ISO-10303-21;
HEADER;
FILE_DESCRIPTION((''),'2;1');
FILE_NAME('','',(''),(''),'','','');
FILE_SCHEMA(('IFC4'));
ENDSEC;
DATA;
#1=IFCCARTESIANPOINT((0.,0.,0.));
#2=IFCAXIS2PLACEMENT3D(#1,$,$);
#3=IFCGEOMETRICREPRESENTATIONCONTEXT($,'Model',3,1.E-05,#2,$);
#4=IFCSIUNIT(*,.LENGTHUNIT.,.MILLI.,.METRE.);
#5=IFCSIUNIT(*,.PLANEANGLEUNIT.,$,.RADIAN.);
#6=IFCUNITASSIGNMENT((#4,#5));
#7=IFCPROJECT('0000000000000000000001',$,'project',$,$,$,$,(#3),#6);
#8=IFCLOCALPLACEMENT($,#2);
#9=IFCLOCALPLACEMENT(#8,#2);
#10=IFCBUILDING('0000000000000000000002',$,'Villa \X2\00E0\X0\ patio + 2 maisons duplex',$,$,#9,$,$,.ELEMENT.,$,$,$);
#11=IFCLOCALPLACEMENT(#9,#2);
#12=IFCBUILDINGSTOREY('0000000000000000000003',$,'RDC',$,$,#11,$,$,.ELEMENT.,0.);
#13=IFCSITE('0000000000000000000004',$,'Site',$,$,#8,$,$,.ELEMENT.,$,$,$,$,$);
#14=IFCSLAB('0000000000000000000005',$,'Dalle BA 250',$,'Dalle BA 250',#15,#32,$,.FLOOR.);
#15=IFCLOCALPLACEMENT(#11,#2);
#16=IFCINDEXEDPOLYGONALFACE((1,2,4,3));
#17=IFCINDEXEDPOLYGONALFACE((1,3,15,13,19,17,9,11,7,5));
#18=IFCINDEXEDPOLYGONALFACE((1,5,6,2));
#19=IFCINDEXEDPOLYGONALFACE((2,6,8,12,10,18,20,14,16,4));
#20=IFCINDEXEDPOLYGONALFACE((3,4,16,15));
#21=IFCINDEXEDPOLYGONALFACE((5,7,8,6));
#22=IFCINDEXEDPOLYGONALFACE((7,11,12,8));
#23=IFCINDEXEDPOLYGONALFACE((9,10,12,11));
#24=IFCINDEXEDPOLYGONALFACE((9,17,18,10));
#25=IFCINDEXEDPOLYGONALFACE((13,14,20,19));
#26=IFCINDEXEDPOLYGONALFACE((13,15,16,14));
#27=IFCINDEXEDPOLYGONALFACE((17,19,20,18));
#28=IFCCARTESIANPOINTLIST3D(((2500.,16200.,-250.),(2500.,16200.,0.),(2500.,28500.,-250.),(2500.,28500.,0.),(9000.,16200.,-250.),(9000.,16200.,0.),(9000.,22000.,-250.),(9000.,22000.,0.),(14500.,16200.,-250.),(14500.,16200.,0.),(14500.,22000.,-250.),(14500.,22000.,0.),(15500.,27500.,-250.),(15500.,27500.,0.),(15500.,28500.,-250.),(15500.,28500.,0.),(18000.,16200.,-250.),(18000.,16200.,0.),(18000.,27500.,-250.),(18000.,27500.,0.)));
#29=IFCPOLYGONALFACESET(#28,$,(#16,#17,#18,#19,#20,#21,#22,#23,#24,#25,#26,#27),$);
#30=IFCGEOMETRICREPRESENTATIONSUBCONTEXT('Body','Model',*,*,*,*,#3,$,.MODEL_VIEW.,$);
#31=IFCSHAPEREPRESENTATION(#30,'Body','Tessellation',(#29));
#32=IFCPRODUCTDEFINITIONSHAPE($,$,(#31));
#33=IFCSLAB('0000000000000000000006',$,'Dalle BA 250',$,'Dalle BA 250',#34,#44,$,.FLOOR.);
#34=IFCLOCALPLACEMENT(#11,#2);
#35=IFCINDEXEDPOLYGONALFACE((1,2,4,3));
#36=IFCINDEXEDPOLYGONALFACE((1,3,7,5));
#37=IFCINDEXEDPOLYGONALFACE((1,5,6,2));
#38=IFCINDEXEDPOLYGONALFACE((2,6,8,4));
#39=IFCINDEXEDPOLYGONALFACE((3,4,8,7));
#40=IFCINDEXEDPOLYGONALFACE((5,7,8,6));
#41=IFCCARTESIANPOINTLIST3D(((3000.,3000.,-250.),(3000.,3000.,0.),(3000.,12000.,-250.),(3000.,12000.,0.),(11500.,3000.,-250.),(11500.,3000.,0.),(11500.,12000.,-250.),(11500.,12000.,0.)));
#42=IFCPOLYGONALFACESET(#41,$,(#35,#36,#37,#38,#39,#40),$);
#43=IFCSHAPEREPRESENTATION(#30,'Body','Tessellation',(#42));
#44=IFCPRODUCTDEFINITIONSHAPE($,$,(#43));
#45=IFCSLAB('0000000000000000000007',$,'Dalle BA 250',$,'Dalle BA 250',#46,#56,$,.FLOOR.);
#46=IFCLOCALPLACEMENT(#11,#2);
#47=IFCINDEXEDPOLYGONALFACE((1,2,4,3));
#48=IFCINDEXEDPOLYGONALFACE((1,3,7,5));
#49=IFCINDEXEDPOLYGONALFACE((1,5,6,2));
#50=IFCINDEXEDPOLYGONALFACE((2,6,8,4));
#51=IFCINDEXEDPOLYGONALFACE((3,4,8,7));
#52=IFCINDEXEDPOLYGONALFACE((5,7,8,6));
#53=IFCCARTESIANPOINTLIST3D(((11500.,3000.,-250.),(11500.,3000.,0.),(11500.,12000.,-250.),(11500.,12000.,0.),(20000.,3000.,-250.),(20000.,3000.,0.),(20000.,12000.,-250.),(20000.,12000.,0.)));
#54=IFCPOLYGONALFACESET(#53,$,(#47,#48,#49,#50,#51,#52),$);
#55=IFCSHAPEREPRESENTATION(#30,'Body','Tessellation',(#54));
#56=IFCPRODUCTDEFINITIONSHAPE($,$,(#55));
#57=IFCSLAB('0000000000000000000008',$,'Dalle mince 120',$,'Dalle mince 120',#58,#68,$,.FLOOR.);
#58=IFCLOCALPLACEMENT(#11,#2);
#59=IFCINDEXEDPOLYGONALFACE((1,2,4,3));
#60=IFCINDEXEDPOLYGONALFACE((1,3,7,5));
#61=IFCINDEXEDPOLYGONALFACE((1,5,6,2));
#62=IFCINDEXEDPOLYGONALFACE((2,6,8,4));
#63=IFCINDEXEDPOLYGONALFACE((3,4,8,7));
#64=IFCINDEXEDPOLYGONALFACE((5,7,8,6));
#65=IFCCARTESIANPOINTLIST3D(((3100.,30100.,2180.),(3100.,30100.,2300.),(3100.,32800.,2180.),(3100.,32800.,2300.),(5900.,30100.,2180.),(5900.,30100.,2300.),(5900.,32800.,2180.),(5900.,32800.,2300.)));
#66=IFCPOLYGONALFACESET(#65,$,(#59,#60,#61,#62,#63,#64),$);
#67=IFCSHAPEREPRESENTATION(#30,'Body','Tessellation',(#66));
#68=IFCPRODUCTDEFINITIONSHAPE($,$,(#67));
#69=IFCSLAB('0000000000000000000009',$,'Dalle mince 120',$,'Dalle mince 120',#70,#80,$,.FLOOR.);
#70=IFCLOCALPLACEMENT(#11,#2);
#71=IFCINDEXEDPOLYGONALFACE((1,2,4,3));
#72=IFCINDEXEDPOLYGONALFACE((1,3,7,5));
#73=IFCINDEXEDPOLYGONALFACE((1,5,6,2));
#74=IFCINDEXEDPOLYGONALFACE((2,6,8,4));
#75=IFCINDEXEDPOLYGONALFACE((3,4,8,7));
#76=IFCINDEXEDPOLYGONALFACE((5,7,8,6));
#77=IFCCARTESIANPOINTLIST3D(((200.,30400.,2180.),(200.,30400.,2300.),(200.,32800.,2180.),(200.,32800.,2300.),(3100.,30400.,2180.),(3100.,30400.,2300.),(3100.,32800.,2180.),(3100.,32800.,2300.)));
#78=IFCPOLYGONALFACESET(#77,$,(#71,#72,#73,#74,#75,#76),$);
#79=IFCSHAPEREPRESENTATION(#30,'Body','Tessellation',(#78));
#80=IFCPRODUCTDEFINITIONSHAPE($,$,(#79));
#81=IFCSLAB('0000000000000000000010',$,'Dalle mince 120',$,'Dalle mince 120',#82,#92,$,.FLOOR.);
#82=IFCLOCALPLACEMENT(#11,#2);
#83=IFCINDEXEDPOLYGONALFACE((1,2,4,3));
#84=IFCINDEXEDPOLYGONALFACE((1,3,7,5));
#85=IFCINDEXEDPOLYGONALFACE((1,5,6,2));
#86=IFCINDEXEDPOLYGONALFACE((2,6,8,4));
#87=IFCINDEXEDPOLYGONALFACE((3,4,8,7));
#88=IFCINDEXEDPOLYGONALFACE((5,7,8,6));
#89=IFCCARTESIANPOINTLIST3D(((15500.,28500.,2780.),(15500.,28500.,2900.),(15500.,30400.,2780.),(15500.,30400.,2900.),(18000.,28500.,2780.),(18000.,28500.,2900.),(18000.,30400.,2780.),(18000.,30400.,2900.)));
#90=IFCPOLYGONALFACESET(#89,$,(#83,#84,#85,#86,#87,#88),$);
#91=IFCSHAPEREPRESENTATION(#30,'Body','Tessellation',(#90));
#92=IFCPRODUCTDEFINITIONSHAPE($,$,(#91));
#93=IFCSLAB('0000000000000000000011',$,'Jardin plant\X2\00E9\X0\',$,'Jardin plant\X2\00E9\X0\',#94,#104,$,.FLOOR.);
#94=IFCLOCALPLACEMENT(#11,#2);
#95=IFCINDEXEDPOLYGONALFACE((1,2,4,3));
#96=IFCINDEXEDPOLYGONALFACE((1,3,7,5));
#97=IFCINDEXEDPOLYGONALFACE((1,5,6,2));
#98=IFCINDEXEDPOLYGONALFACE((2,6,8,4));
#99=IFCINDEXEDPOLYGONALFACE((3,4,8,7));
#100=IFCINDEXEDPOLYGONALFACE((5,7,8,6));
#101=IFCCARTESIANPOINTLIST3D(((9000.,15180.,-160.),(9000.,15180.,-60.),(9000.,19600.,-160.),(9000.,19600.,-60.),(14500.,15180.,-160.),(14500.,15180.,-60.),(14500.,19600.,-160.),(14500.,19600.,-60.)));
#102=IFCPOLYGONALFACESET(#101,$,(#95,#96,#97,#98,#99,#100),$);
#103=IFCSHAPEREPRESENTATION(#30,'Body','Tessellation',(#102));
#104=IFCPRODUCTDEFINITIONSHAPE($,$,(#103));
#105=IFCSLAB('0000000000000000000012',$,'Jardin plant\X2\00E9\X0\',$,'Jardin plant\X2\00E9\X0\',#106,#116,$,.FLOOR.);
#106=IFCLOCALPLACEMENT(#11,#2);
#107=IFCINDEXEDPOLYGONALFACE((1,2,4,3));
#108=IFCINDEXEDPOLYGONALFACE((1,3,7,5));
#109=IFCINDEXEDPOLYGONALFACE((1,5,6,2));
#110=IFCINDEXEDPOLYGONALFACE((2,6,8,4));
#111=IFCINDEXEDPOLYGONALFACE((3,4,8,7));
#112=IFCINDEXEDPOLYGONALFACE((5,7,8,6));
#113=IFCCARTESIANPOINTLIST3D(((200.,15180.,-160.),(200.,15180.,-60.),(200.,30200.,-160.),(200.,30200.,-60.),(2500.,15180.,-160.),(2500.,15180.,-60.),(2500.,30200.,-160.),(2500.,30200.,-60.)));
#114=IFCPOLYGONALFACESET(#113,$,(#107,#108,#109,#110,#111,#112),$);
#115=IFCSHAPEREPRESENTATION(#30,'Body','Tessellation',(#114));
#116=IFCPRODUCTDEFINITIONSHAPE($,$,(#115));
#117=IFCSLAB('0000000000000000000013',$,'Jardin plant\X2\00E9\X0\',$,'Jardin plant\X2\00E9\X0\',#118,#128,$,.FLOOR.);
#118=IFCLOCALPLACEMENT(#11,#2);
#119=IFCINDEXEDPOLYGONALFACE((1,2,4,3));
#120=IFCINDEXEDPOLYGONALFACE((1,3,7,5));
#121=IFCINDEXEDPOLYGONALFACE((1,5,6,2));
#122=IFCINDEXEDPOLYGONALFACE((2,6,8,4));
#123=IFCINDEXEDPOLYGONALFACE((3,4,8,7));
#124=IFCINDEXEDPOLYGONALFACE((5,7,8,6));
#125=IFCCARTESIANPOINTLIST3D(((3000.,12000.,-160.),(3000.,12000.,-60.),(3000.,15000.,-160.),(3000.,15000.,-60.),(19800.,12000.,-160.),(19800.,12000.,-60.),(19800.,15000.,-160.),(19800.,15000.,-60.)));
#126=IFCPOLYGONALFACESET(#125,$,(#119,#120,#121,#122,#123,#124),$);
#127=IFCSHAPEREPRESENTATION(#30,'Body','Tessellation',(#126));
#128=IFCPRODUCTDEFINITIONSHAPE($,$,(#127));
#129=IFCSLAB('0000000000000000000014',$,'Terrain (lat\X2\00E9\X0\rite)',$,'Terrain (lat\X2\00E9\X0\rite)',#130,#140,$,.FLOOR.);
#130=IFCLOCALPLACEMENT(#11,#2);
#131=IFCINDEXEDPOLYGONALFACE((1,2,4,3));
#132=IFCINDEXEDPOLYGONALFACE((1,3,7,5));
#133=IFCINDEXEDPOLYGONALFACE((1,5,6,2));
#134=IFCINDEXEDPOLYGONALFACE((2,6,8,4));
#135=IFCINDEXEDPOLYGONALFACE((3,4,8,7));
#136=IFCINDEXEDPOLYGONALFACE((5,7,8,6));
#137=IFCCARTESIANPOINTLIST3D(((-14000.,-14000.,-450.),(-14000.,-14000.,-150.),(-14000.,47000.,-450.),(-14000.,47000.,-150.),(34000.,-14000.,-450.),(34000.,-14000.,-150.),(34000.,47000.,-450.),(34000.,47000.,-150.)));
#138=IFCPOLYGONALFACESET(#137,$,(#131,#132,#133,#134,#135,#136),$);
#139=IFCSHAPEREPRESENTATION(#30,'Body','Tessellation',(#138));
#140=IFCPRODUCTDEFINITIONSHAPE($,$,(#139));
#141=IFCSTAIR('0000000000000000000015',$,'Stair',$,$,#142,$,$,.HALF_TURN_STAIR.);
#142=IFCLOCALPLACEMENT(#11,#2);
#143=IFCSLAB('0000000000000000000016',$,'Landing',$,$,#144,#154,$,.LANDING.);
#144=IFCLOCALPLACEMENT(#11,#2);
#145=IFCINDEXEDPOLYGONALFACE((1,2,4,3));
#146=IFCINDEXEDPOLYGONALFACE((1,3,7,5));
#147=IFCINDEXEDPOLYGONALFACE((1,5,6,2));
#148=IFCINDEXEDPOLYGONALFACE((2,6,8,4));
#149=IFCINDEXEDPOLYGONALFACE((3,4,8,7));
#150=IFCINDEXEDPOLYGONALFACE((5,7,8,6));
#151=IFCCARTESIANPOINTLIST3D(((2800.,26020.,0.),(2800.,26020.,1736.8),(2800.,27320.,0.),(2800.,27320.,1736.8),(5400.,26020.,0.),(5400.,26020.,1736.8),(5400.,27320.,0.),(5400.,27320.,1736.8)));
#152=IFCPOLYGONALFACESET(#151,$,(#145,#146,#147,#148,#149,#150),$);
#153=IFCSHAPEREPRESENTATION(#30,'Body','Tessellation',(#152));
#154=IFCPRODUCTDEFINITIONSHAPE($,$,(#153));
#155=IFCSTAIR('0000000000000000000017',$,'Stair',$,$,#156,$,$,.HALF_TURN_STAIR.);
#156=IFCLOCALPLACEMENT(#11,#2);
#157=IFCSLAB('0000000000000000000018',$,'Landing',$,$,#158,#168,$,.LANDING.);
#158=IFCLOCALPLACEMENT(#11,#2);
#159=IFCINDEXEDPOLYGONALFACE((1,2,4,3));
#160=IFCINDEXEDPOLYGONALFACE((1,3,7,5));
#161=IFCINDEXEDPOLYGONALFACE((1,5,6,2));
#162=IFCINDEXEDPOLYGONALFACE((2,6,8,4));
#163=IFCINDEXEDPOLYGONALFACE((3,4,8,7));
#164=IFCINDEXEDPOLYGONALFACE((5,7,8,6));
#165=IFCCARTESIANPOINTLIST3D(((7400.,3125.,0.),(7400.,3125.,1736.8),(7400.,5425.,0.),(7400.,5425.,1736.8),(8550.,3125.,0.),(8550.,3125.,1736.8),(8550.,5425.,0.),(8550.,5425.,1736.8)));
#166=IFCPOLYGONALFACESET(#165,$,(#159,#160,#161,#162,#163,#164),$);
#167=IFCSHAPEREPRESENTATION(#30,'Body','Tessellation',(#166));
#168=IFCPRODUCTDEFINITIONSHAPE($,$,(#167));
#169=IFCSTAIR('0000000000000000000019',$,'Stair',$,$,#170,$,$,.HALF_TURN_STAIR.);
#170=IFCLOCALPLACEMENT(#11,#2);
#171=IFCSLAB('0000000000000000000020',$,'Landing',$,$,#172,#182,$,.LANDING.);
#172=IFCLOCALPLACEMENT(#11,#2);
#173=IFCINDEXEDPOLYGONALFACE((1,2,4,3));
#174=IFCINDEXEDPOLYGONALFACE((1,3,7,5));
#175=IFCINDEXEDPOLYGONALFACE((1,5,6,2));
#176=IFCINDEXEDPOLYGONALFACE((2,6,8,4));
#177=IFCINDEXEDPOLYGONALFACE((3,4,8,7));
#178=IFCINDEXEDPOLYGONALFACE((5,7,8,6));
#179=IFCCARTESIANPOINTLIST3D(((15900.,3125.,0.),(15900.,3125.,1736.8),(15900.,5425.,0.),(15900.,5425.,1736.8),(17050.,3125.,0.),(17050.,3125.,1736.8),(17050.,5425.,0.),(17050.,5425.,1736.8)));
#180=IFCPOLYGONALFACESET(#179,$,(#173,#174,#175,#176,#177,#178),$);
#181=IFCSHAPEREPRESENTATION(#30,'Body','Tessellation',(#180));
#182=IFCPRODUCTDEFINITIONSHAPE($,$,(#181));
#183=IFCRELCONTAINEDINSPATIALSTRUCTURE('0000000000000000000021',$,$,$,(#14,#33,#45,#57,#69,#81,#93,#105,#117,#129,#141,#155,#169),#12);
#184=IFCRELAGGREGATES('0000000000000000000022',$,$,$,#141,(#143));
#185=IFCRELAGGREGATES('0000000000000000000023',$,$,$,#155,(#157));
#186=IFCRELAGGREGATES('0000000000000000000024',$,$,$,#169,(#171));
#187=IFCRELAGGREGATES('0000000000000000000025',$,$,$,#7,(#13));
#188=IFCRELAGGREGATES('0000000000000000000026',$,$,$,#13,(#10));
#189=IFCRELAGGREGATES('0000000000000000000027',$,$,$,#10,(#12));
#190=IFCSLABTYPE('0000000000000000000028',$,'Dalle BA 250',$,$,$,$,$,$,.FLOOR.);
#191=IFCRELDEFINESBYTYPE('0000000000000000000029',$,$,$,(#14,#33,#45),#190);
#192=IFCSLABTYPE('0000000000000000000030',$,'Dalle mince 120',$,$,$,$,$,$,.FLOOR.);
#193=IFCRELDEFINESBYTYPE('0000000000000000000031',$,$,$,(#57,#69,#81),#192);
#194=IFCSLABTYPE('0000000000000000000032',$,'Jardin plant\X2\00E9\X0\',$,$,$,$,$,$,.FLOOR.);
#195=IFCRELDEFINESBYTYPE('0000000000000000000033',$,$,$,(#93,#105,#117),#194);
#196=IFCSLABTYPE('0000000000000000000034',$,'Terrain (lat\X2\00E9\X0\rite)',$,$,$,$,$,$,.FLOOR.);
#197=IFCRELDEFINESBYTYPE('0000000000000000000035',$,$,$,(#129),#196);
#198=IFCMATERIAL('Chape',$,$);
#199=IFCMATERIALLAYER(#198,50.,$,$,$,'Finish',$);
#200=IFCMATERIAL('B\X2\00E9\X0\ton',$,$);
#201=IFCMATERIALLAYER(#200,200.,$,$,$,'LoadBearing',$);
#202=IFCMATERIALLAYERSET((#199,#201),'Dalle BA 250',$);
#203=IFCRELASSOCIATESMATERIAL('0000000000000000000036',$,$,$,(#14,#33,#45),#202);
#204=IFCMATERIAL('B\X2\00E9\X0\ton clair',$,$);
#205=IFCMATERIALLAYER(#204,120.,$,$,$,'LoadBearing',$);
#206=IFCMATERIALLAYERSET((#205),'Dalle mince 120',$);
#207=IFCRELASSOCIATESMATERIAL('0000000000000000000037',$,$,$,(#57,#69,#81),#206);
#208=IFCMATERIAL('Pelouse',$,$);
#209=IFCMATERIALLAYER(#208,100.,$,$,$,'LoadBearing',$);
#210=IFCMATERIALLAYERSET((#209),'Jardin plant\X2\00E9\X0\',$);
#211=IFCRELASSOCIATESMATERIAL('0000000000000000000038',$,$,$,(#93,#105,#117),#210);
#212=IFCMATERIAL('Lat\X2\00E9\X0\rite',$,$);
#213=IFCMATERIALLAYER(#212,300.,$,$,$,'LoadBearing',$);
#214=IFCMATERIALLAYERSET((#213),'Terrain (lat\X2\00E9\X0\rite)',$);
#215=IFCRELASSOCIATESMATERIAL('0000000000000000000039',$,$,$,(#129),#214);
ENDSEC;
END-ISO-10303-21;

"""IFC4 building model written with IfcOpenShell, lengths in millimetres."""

from ifc_helpers import new_model, si_unit, frame, origin, place, context, subcontext, project, spatial, polyline, outline, extrude, material, layer, layer_set, layer_usage, type_object, element, aggregate, save


model = new_model("IFC4")

# Units and contexts
model_context = context("Model", 3, precision=1e-05, world=origin())
body_context = subcontext(model_context, "Body", "Model", "MODEL_VIEW")
ifc_project = project(units=[si_unit("LENGTHUNIT", "METRE", prefix="MILLI"), si_unit("PLANEANGLEUNIT", "RADIAN")], contexts=[model_context])

# Site, building, storey
site_placement = place(None, origin())
site = spatial("IfcSite", under=ifc_project, at=site_placement, Name="Site", CompositionType="ELEMENT")
building_placement = place(site_placement, origin())
building = spatial("IfcBuilding", under=site, at=building_placement, Name="Villa à patio + 2 maisons duplex", CompositionType="ELEMENT")
storey_placement = place(building_placement, origin())
storey = spatial("IfcBuildingStorey", under=building, at=storey_placement, Name="RDC", CompositionType="ELEMENT", Elevation=0.0)

# Slabs
ifc_material_1 = material(Name="Chape")
ifc_layer_1 = layer(ifc_material_1, 50.0, Category="Finish")
ifc_material_2 = material(Name="Béton")
ifc_layer_2 = layer(ifc_material_2, 200.0, Category="LoadBearing")
ifc_layer_set_1 = layer_set([ifc_layer_1, ifc_layer_2], Name="Dalle BA 250")
ifc_layer_usage_1 = layer_usage(ifc_layer_set_1, "AXIS3", "NEGATIVE", 0.0)
slab_type_1 = type_object("IfcSlabType", Name="Dalle BA 250", PredefinedType="FLOOR")
slab_1_placement = place(storey_placement, origin())
element("IfcSlab", 1, at=slab_1_placement, inside=storey, type_object=slab_type_1, material=ifc_layer_usage_1, Name="Dalle BA 250", ObjectType="Dalle BA 250", PredefinedType="FLOOR", context=body_context, shape_type="SweptSolid", body=[
    extrude(outline(polyline([(9000.0, 16200.0), (9000.0, 22000.0), (14500.0, 22000.0), (14500.0, 16200.0), (18000.0, 16200.0), (18000.0, 27500.0), (15500.0, 27500.0), (15500.0, 28500.0), (2500.0, 28500.0), (2500.0, 16200.0), (9000.0, 16200.0)])), frame((0.0, 0.0, -250.0)), (0.0, 0.0, 1.0), 250.0),
])
slab_2_placement = place(storey_placement, origin())
element("IfcSlab", 2, at=slab_2_placement, inside=storey, type_object=slab_type_1, material=ifc_layer_usage_1, Name="Dalle BA 250", ObjectType="Dalle BA 250", PredefinedType="FLOOR", context=body_context, shape_type="SweptSolid", body=[
    extrude(outline(polyline([(3000.0, 12000.0), (3000.0, 3000.0), (11500.0, 3000.0), (11500.0, 12000.0), (3000.0, 12000.0)])), frame((0.0, 0.0, -250.0)), (0.0, 0.0, 1.0), 250.0),
])
slab_3_placement = place(storey_placement, origin())
element("IfcSlab", 3, at=slab_3_placement, inside=storey, type_object=slab_type_1, material=ifc_layer_usage_1, Name="Dalle BA 250", ObjectType="Dalle BA 250", PredefinedType="FLOOR", context=body_context, shape_type="SweptSolid", body=[
    extrude(outline(polyline([(11500.0, 12000.0), (11500.0, 3000.0), (20000.0, 3000.0), (20000.0, 12000.0), (11500.0, 12000.0)])), frame((0.0, 0.0, -250.0)), (0.0, 0.0, 1.0), 250.0),
])
ifc_material_3 = material(Name="Béton clair")
ifc_layer_3 = layer(ifc_material_3, 120.0, Category="LoadBearing")
ifc_layer_set_2 = layer_set([ifc_layer_3], Name="Dalle mince 120")
ifc_layer_usage_2 = layer_usage(ifc_layer_set_2, "AXIS3", "NEGATIVE", 2300.0)
slab_type_2 = type_object("IfcSlabType", Name="Dalle mince 120", PredefinedType="FLOOR")
slab_4_placement = place(storey_placement, origin())
element("IfcSlab", 4, at=slab_4_placement, inside=storey, type_object=slab_type_2, material=ifc_layer_usage_2, Name="Dalle mince 120", ObjectType="Dalle mince 120", PredefinedType="FLOOR", context=body_context, shape_type="SweptSolid", body=[
    extrude(outline(polyline([(3100.0, 32800.0), (3100.0, 30100.0), (5900.0, 30100.0), (5900.0, 32800.0), (3100.0, 32800.0)])), frame((0.0, 0.0, 2180.0)), (0.0, 0.0, 1.0), 120.0),
])
slab_5_placement = place(storey_placement, origin())
element("IfcSlab", 5, at=slab_5_placement, inside=storey, type_object=slab_type_2, material=ifc_layer_usage_2, Name="Dalle mince 120", ObjectType="Dalle mince 120", PredefinedType="FLOOR", context=body_context, shape_type="SweptSolid", body=[
    extrude(outline(polyline([(200.0, 32800.0), (200.0, 30400.0), (3100.0, 30400.0), (3100.0, 32800.0), (200.0, 32800.0)])), frame((0.0, 0.0, 2180.0)), (0.0, 0.0, 1.0), 120.0),
])
ifc_layer_usage_3 = layer_usage(ifc_layer_set_2, "AXIS3", "NEGATIVE", 2900.0)
slab_6_placement = place(storey_placement, origin())
element("IfcSlab", 6, at=slab_6_placement, inside=storey, type_object=slab_type_2, material=ifc_layer_usage_3, Name="Dalle mince 120", ObjectType="Dalle mince 120", PredefinedType="FLOOR", context=body_context, shape_type="SweptSolid", body=[
    extrude(outline(polyline([(15500.0, 30400.0), (15500.0, 28500.0), (18000.0, 28500.0), (18000.0, 30400.0), (15500.0, 30400.0)])), frame((0.0, 0.0, 2780.0)), (0.0, 0.0, 1.0), 120.0),
])
ifc_material_4 = material(Name="Pelouse")
ifc_layer_4 = layer(ifc_material_4, 100.0, Category="LoadBearing")
ifc_layer_set_3 = layer_set([ifc_layer_4], Name="Jardin planté")
ifc_layer_usage_4 = layer_usage(ifc_layer_set_3, "AXIS3", "NEGATIVE", -60.0)
slab_type_3 = type_object("IfcSlabType", Name="Jardin planté", PredefinedType="FLOOR")
slab_7_placement = place(storey_placement, origin())
element("IfcSlab", 7, at=slab_7_placement, inside=storey, type_object=slab_type_3, material=ifc_layer_usage_4, Name="Jardin planté", ObjectType="Jardin planté", PredefinedType="FLOOR", context=body_context, shape_type="SweptSolid", body=[
    extrude(outline(polyline([(9000.0, 19600.0), (9000.0, 15180.0), (14500.0, 15180.0), (14500.0, 19600.0), (9000.0, 19600.0)])), frame((0.0, 0.0, -160.0)), (0.0, 0.0, 1.0), 100.0),
])
slab_8_placement = place(storey_placement, origin())
element("IfcSlab", 8, at=slab_8_placement, inside=storey, type_object=slab_type_3, material=ifc_layer_usage_4, Name="Jardin planté", ObjectType="Jardin planté", PredefinedType="FLOOR", context=body_context, shape_type="SweptSolid", body=[
    extrude(outline(polyline([(200.0, 30200.0), (200.0, 15180.0), (2500.0, 15180.0), (2500.0, 30200.0), (200.0, 30200.0)])), frame((0.0, 0.0, -160.0)), (0.0, 0.0, 1.0), 100.0),
])
slab_9_placement = place(storey_placement, origin())
element("IfcSlab", 9, at=slab_9_placement, inside=storey, type_object=slab_type_3, material=ifc_layer_usage_4, Name="Jardin planté", ObjectType="Jardin planté", PredefinedType="FLOOR", context=body_context, shape_type="SweptSolid", body=[
    extrude(outline(polyline([(3000.0, 15000.0), (3000.0, 12000.0), (19800.0, 12000.0), (19800.0, 15000.0), (3000.0, 15000.0)])), frame((0.0, 0.0, -160.0)), (0.0, 0.0, 1.0), 100.0),
])
ifc_material_5 = material(Name="Latérite")
ifc_layer_5 = layer(ifc_material_5, 300.0, Category="LoadBearing")
ifc_layer_set_4 = layer_set([ifc_layer_5], Name="Terrain (latérite)")
ifc_layer_usage_5 = layer_usage(ifc_layer_set_4, "AXIS3", "NEGATIVE", -150.0)
slab_type_4 = type_object("IfcSlabType", Name="Terrain (latérite)", PredefinedType="FLOOR")
slab_10_placement = place(storey_placement, origin())
element("IfcSlab", 10, at=slab_10_placement, inside=storey, type_object=slab_type_4, material=ifc_layer_usage_5, Name="Terrain (latérite)", ObjectType="Terrain (latérite)", PredefinedType="FLOOR", context=body_context, shape_type="SweptSolid", body=[
    extrude(outline(polyline([(-14000.0, -14000.0), (34000.0, -14000.0), (34000.0, 47000.0), (-14000.0, 47000.0), (-14000.0, -14000.0)])), frame((0.0, 0.0, -450.0)), (0.0, 0.0, 1.0), 300.0),
])

# Stairs, slabs
stair_1_placement = place(storey_placement, origin())
stair_1 = element("IfcStair", 11, at=stair_1_placement, inside=storey, Name="Stair", PredefinedType="HALF_TURN_STAIR")
slab_11_placement = place(stair_1_placement, origin())
slab_11 = element("IfcSlab", 12, at=slab_11_placement, Name="Landing", PredefinedType="LANDING", context=body_context, shape_type="SweptSolid", body=[
    extrude(outline(polyline([(5400.0, 26020.0), (5400.0, 27320.0), (2800.0, 27320.0), (2800.0, 26020.0), (5400.0, 26020.0)])), origin(), (0.0, 0.0, 1.0), 1736.8),
])
aggregate(stair_1, [slab_11])
stair_2_placement = place(storey_placement, origin())
stair_2 = element("IfcStair", 13, at=stair_2_placement, inside=storey, Name="Stair", PredefinedType="HALF_TURN_STAIR")
slab_12_placement = place(stair_2_placement, origin())
slab_12 = element("IfcSlab", 14, at=slab_12_placement, Name="Landing", PredefinedType="LANDING", context=body_context, shape_type="SweptSolid", body=[
    extrude(outline(polyline([(7400.0, 3125.0), (8550.0, 3125.0), (8550.0, 5425.0), (7400.0, 5425.0), (7400.0, 3125.0)])), origin(), (0.0, 0.0, 1.0), 1736.8),
])
aggregate(stair_2, [slab_12])
stair_3_placement = place(storey_placement, origin())
stair_3 = element("IfcStair", 15, at=stair_3_placement, inside=storey, Name="Stair", PredefinedType="HALF_TURN_STAIR")
slab_13_placement = place(stair_3_placement, origin())
slab_13 = element("IfcSlab", 16, at=slab_13_placement, Name="Landing", PredefinedType="LANDING", context=body_context, shape_type="SweptSolid", body=[
    extrude(outline(polyline([(15900.0, 3125.0), (17050.0, 3125.0), (17050.0, 5425.0), (15900.0, 5425.0), (15900.0, 3125.0)])), origin(), (0.0, 0.0, 1.0), 1736.8),
])
aggregate(stair_3, [slab_13])

save(model, "model.ifc")
